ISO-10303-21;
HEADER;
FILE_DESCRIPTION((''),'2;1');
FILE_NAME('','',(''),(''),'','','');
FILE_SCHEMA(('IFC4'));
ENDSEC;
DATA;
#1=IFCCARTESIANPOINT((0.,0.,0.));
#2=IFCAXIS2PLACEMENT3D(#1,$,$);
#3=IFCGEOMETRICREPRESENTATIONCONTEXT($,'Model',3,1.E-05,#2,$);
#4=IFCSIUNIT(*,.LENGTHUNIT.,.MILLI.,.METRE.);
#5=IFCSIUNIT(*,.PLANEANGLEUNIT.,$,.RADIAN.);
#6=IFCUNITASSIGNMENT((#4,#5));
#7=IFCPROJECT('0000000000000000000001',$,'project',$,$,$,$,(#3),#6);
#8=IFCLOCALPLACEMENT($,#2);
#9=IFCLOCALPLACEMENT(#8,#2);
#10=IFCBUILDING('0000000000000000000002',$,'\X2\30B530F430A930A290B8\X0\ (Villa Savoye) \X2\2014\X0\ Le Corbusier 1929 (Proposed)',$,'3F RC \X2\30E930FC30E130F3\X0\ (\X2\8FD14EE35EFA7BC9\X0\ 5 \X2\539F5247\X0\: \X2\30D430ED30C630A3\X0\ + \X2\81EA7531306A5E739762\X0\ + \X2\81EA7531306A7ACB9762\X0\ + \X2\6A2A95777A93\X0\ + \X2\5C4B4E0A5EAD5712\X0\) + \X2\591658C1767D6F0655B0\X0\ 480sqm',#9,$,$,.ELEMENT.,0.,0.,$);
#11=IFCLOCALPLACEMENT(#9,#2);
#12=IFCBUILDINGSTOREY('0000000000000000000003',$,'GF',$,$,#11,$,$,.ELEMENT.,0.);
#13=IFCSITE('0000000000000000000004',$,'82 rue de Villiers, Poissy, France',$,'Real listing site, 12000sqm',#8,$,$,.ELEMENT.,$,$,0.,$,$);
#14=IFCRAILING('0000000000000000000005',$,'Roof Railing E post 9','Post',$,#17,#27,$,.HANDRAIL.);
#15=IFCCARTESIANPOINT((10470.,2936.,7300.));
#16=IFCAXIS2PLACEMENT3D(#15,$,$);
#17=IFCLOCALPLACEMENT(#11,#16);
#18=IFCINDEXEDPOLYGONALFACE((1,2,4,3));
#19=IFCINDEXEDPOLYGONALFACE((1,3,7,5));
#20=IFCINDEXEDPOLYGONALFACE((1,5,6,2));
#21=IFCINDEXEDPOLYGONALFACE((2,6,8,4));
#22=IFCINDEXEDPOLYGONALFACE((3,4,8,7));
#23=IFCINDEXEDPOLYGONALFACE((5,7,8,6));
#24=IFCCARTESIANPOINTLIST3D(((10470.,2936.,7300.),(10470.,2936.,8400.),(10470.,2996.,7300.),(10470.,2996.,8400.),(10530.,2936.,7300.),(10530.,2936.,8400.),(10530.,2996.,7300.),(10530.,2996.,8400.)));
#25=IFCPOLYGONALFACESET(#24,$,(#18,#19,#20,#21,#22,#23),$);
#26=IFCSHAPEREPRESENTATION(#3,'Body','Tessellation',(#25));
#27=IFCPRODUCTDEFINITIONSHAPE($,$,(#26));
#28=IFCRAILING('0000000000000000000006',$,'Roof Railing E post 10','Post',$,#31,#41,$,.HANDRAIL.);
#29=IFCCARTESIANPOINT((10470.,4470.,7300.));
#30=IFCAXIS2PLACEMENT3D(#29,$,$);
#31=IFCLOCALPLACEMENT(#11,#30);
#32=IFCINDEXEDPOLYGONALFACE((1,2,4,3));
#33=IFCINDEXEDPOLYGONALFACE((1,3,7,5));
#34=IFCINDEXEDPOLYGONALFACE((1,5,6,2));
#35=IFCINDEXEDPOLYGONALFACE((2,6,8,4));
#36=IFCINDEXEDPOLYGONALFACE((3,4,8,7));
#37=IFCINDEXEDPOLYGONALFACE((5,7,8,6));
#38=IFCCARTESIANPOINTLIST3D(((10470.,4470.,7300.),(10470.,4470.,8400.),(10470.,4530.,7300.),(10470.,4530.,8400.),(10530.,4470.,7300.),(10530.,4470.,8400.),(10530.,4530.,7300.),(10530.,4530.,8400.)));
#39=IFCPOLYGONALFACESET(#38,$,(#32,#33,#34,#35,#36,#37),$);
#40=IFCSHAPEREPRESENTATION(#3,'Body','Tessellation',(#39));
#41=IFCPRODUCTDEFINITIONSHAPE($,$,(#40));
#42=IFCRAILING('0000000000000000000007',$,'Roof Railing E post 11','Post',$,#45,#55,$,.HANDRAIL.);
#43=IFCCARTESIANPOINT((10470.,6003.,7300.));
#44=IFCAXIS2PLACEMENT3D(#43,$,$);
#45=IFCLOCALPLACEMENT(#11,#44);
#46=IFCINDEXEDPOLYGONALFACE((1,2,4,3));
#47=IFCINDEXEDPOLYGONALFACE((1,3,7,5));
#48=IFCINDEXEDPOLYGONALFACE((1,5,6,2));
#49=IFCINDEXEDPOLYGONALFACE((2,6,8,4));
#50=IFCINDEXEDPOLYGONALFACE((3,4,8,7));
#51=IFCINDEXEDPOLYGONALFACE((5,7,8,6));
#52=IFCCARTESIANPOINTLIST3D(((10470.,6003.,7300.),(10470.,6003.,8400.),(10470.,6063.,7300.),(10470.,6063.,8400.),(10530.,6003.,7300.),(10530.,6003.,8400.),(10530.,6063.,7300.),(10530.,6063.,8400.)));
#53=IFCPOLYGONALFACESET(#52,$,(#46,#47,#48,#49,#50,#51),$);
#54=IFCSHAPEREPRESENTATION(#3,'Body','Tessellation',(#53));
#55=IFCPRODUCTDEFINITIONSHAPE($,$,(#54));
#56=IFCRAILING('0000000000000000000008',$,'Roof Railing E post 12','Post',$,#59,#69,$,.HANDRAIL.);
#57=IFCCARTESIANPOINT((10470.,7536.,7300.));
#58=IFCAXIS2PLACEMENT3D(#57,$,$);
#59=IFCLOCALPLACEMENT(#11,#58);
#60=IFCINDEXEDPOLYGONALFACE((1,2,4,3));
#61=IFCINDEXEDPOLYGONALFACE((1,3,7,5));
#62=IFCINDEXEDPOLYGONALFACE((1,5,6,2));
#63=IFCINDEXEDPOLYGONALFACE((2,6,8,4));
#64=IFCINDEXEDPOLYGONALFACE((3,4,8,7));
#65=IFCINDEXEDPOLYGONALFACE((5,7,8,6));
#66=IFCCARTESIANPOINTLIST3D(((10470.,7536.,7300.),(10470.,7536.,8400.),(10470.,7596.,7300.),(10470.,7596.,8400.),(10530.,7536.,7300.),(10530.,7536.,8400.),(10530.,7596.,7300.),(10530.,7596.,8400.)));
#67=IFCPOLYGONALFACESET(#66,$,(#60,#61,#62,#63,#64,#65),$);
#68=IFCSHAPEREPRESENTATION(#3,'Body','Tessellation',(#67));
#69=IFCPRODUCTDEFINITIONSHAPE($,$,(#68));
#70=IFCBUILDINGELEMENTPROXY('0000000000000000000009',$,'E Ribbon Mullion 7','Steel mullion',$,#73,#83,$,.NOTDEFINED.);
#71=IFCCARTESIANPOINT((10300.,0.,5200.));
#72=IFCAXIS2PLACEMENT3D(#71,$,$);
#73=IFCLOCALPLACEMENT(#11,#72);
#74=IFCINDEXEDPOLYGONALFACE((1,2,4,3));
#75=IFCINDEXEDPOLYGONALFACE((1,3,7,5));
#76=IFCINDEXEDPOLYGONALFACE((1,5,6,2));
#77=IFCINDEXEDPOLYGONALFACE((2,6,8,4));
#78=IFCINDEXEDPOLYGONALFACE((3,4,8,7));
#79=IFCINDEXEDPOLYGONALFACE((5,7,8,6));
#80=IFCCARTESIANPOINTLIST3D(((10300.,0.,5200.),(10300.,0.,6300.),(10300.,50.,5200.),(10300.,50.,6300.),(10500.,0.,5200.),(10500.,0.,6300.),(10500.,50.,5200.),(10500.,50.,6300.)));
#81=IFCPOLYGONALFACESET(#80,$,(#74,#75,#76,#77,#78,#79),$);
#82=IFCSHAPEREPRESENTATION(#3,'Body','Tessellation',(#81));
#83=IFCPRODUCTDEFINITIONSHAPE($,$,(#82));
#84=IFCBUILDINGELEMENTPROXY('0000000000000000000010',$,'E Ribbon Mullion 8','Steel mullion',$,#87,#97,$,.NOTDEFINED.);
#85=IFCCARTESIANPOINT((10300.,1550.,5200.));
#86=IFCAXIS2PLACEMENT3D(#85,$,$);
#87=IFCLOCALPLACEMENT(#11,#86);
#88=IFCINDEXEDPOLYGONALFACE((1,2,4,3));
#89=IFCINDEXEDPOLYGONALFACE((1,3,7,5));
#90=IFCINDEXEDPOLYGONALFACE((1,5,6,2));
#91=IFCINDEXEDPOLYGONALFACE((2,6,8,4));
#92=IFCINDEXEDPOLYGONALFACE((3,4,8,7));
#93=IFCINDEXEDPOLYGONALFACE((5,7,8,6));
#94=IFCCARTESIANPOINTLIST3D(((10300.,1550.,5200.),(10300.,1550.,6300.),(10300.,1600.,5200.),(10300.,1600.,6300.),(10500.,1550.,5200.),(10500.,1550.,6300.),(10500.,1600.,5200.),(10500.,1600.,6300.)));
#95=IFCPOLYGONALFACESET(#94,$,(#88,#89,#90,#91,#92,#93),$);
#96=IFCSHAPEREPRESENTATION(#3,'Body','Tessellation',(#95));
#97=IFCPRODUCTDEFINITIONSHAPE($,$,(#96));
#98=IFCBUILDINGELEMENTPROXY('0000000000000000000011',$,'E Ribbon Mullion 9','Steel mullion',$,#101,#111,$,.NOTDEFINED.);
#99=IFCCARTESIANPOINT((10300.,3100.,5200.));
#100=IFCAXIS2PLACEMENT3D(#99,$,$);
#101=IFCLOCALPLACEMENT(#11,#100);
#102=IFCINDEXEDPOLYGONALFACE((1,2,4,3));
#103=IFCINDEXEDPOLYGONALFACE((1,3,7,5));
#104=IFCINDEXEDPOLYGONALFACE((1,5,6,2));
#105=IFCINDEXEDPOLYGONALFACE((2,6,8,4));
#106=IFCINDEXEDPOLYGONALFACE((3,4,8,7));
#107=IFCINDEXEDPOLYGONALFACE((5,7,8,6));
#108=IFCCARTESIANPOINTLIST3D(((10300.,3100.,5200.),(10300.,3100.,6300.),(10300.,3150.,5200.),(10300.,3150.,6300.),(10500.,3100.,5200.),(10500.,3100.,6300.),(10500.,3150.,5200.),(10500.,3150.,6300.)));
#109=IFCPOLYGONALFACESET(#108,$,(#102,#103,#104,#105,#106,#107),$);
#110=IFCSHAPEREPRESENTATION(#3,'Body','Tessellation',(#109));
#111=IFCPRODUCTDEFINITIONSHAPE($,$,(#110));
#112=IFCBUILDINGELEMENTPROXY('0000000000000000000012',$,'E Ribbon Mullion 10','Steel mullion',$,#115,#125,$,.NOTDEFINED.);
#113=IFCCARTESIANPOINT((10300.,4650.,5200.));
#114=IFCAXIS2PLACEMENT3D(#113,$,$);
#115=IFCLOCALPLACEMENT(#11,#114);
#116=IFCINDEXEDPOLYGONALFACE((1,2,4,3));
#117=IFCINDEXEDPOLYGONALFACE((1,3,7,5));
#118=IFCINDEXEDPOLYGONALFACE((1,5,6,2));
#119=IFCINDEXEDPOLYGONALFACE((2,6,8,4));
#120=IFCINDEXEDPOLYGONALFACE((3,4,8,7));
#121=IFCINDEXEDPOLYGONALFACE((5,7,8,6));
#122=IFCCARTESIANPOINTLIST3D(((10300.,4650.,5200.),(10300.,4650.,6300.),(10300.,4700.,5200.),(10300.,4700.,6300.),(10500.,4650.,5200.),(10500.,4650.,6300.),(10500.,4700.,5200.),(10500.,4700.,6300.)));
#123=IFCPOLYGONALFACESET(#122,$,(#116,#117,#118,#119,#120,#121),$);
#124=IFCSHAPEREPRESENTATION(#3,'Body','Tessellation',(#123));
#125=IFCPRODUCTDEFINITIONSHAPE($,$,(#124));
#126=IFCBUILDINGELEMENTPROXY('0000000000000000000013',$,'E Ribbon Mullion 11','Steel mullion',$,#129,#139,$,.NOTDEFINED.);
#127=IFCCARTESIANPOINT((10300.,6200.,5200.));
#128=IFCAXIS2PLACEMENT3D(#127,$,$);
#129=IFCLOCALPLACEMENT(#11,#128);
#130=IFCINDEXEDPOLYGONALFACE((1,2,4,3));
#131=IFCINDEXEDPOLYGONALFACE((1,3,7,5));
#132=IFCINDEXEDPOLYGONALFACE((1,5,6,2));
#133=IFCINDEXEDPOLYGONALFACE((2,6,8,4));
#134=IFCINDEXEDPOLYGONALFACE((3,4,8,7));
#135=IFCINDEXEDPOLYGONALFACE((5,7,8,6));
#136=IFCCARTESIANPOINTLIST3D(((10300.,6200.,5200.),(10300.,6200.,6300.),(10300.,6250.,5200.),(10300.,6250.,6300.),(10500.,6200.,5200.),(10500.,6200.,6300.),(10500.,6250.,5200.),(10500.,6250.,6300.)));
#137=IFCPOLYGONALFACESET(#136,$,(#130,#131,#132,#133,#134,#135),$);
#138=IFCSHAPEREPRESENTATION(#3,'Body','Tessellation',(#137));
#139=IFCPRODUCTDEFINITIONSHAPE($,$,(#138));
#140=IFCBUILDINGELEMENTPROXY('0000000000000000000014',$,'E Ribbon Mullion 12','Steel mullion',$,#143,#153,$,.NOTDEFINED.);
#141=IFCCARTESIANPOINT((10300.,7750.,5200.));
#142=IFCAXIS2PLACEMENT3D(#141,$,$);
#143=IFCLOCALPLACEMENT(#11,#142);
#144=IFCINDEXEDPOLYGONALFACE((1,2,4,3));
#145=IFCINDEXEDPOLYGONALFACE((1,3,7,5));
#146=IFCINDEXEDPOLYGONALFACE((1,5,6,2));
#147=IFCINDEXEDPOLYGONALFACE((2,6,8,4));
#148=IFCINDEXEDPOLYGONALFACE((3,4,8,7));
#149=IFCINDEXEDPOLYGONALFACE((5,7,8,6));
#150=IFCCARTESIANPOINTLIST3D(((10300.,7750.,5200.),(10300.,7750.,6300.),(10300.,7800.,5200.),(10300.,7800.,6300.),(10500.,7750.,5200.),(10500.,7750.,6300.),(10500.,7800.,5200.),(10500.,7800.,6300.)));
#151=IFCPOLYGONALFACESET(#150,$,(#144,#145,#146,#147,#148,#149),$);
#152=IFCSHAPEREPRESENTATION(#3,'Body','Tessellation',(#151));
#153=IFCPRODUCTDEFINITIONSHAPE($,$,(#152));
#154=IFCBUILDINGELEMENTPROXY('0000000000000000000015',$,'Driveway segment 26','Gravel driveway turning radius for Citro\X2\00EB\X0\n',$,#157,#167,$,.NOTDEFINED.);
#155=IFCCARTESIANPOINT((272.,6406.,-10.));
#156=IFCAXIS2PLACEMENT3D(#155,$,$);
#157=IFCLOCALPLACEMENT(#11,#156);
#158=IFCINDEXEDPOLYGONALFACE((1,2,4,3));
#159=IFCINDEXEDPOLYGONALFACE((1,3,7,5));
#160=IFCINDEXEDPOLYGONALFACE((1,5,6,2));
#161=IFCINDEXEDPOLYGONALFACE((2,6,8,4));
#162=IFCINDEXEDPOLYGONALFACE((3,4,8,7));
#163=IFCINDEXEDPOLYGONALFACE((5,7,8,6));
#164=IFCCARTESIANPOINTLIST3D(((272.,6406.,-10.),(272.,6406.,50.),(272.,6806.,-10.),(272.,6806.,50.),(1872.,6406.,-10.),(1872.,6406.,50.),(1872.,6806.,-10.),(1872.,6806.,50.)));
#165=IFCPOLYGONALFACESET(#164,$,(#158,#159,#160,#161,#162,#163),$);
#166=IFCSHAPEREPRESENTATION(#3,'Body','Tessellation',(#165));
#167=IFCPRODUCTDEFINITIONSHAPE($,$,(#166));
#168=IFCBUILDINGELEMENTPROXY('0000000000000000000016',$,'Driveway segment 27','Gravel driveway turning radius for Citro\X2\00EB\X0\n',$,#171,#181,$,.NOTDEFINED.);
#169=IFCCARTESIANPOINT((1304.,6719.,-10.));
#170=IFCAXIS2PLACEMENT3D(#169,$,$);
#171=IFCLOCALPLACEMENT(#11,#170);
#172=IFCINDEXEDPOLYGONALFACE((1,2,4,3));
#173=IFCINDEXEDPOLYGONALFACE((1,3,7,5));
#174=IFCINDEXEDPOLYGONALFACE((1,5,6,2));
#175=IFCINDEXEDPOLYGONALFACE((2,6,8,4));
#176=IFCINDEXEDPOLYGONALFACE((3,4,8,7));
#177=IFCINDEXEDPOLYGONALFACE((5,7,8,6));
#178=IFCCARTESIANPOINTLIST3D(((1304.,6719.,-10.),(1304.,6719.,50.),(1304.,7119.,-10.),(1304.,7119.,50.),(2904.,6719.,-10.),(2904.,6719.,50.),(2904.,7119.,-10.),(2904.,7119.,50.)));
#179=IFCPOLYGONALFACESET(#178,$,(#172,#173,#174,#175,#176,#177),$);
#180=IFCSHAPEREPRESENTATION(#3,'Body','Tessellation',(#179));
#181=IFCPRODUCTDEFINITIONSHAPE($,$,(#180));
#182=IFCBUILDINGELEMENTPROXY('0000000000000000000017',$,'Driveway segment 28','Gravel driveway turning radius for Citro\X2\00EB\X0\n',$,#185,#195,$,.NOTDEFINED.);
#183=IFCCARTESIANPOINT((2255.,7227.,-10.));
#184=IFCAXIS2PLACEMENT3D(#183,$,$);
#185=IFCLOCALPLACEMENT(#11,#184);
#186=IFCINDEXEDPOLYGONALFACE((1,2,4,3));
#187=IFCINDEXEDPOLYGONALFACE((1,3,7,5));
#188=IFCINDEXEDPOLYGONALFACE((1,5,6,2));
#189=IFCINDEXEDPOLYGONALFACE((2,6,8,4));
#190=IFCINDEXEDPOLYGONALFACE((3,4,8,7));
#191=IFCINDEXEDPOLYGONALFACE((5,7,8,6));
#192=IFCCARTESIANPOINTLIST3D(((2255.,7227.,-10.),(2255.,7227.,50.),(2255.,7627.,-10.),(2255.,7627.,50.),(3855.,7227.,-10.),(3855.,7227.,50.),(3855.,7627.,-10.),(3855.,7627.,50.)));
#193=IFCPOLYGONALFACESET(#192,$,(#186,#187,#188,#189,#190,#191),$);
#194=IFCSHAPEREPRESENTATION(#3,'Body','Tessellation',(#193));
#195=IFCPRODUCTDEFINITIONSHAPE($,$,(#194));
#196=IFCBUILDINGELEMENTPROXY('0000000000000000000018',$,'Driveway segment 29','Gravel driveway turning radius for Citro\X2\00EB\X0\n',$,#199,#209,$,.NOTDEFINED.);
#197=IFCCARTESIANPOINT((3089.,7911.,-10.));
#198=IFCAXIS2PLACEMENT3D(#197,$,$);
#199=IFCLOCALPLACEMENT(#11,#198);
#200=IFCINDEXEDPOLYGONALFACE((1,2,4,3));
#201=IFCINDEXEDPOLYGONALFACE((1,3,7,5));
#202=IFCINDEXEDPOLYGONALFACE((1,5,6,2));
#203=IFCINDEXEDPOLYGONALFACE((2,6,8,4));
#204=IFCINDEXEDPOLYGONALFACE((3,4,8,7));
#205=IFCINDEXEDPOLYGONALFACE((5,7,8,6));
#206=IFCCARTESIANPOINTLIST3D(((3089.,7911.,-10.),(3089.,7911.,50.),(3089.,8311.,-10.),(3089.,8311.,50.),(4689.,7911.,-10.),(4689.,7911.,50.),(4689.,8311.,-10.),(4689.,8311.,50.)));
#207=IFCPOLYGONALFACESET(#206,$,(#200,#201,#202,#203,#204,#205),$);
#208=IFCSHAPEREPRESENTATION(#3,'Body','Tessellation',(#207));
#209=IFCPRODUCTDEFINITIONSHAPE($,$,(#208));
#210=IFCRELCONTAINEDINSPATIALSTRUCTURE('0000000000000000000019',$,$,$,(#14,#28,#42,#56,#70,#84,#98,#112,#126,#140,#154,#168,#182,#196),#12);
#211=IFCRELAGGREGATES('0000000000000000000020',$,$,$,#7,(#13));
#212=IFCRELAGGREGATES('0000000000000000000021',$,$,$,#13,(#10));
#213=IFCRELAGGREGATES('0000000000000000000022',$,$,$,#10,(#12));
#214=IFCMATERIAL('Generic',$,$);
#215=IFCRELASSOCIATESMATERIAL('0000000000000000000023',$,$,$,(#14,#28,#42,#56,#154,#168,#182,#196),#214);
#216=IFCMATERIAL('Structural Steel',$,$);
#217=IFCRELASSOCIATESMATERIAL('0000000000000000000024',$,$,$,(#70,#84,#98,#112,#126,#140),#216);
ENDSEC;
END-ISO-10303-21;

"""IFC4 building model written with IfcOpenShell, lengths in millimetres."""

from ifc_helpers import new_model, si_unit, frame, frame_2d, origin, place, context, project, spatial, rectangle, extrude, material, element, save


model = new_model("IFC4")

# Units and contexts
model_context = context("Model", 3, precision=1e-05, world=origin())
ifc_project = project(units=[si_unit("LENGTHUNIT", "METRE", prefix="MILLI"), si_unit("PLANEANGLEUNIT", "RADIAN")], contexts=[model_context])

# Site, building, storey
site_placement = place(None, origin())
site = spatial("IfcSite", under=ifc_project, at=site_placement, Name="82 rue de Villiers, Poissy, France", ObjectType="Real listing site, 12000sqm", CompositionType="ELEMENT", RefElevation=0.0)
building_placement = place(site_placement, origin())
building = spatial("IfcBuilding", under=site, at=building_placement, Name="サヴォア邸 (Villa Savoye) — Le Corbusier 1929 (Proposed)", ObjectType="3F RC ラーメン (近代建築 5 原則: ピロティ + 自由な平面 + 自由な立面 + 横長窓 + 屋上庭園) + 外壁白漆喰 480sqm", CompositionType="ELEMENT", ElevationOfRefHeight=0.0, ElevationOfTerrain=0.0)
storey_placement = place(building_placement, origin())
storey = spatial("IfcBuildingStorey", under=building, at=storey_placement, Name="GF", CompositionType="ELEMENT", Elevation=0.0)

# Shared definitions
ifc_material_1 = material(Name="Generic")

# Railings
railing_1_placement = place(storey_placement, frame((10470.0, 2936.0, 7300.0)))
element("IfcRailing", 1, at=railing_1_placement, inside=storey, material=ifc_material_1, Name="Roof Railing E post 9", Description="Post", PredefinedType="HANDRAIL", context=model_context, shape_type="SweptSolid", body=[
    extrude(rectangle(XDim=60.0, YDim=60.0, at=frame_2d((30.0, 30.0))), frame((10470.0, 2936.0, 7300.0)), (0.0, 0.0, 1.0), 1100.0),
])
railing_2_placement = place(storey_placement, frame((10470.0, 4470.0, 7300.0)))
element("IfcRailing", 2, at=railing_2_placement, inside=storey, material=ifc_material_1, Name="Roof Railing E post 10", Description="Post", PredefinedType="HANDRAIL", context=model_context, shape_type="SweptSolid", body=[
    extrude(rectangle(XDim=60.0, YDim=60.0, at=frame_2d((30.0, 30.0))), frame((10470.0, 4470.0, 7300.0)), (0.0, 0.0, 1.0), 1100.0),
])
railing_3_placement = place(storey_placement, frame((10470.0, 6003.0, 7300.0)))
element("IfcRailing", 3, at=railing_3_placement, inside=storey, material=ifc_material_1, Name="Roof Railing E post 11", Description="Post", PredefinedType="HANDRAIL", context=model_context, shape_type="SweptSolid", body=[
    extrude(rectangle(XDim=60.0, YDim=60.0, at=frame_2d((30.0, 30.0))), frame((10470.0, 6003.0, 7300.0)), (0.0, 0.0, 1.0), 1100.0),
])
railing_4_placement = place(storey_placement, frame((10470.0, 7536.0, 7300.0)))
element("IfcRailing", 4, at=railing_4_placement, inside=storey, material=ifc_material_1, Name="Roof Railing E post 12", Description="Post", PredefinedType="HANDRAIL", context=model_context, shape_type="SweptSolid", body=[
    extrude(rectangle(XDim=60.0, YDim=60.0, at=frame_2d((30.0, 30.0))), frame((10470.0, 7536.0, 7300.0)), (0.0, 0.0, 1.0), 1100.0),
])

# Building element proxies
ifc_material_2 = material(Name="Structural Steel")
proxy_1_placement = place(storey_placement, frame((10300.0, 0.0, 5200.0)))
element("IfcBuildingElementProxy", 5, at=proxy_1_placement, inside=storey, material=ifc_material_2, Name="E Ribbon Mullion 7", Description="Steel mullion", PredefinedType="NOTDEFINED", context=model_context, shape_type="SweptSolid", body=[
    extrude(rectangle(XDim=200.0, YDim=50.0, at=frame_2d((100.0, 25.0))), frame((10300.0, 0.0, 5200.0)), (0.0, 0.0, 1.0), 1100.0),
])
proxy_2_placement = place(storey_placement, frame((10300.0, 1550.0, 5200.0)))
element("IfcBuildingElementProxy", 6, at=proxy_2_placement, inside=storey, material=ifc_material_2, Name="E Ribbon Mullion 8", Description="Steel mullion", PredefinedType="NOTDEFINED", context=model_context, shape_type="SweptSolid", body=[
    extrude(rectangle(XDim=200.0, YDim=50.0, at=frame_2d((100.0, 25.0))), frame((10300.0, 1550.0, 5200.0)), (0.0, 0.0, 1.0), 1100.0),
])
proxy_3_placement = place(storey_placement, frame((10300.0, 3100.0, 5200.0)))
element("IfcBuildingElementProxy", 7, at=proxy_3_placement, inside=storey, material=ifc_material_2, Name="E Ribbon Mullion 9", Description="Steel mullion", PredefinedType="NOTDEFINED", context=model_context, shape_type="SweptSolid", body=[
    extrude(rectangle(XDim=200.0, YDim=50.0, at=frame_2d((100.0, 25.0))), frame((10300.0, 3100.0, 5200.0)), (0.0, 0.0, 1.0), 1100.0),
])
proxy_4_placement = place(storey_placement, frame((10300.0, 4650.0, 5200.0)))
element("IfcBuildingElementProxy", 8, at=proxy_4_placement, inside=storey, material=ifc_material_2, Name="E Ribbon Mullion 10", Description="Steel mullion", PredefinedType="NOTDEFINED", context=model_context, shape_type="SweptSolid", body=[
    extrude(rectangle(XDim=200.0, YDim=50.0, at=frame_2d((100.0, 25.0))), frame((10300.0, 4650.0, 5200.0)), (0.0, 0.0, 1.0), 1100.0),
])
proxy_5_placement = place(storey_placement, frame((10300.0, 6200.0, 5200.0)))
element("IfcBuildingElementProxy", 9, at=proxy_5_placement, inside=storey, material=ifc_material_2, Name="E Ribbon Mullion 11", Description="Steel mullion", PredefinedType="NOTDEFINED", context=model_context, shape_type="SweptSolid", body=[
    extrude(rectangle(XDim=200.0, YDim=50.0, at=frame_2d((100.0, 25.0))), frame((10300.0, 6200.0, 5200.0)), (0.0, 0.0, 1.0), 1100.0),
])
proxy_6_placement = place(storey_placement, frame((10300.0, 7750.0, 5200.0)))
element("IfcBuildingElementProxy", 10, at=proxy_6_placement, inside=storey, material=ifc_material_2, Name="E Ribbon Mullion 12", Description="Steel mullion", PredefinedType="NOTDEFINED", context=model_context, shape_type="SweptSolid", body=[
    extrude(rectangle(XDim=200.0, YDim=50.0, at=frame_2d((100.0, 25.0))), frame((10300.0, 7750.0, 5200.0)), (0.0, 0.0, 1.0), 1100.0),
])
proxy_7_placement = place(storey_placement, frame((272.0, 6406.0, -10.0)))
element("IfcBuildingElementProxy", 11, at=proxy_7_placement, inside=storey, material=ifc_material_1, Name="Driveway segment 26", Description="Gravel driveway turning radius for Citroën", PredefinedType="NOTDEFINED", context=model_context, shape_type="SweptSolid", body=[
    extrude(rectangle(XDim=1600.0, YDim=400.0, at=frame_2d((800.0, 200.0))), frame((272.0, 6406.0, -10.0)), (0.0, 0.0, 1.0), 60.0),
])
proxy_8_placement = place(storey_placement, frame((1304.0, 6719.0, -10.0)))
element("IfcBuildingElementProxy", 12, at=proxy_8_placement, inside=storey, material=ifc_material_1, Name="Driveway segment 27", Description="Gravel driveway turning radius for Citroën", PredefinedType="NOTDEFINED", context=model_context, shape_type="SweptSolid", body=[
    extrude(rectangle(XDim=1600.0, YDim=400.0, at=frame_2d((800.0, 200.0))), frame((1304.0, 6719.0, -10.0)), (0.0, 0.0, 1.0), 60.0),
])
proxy_9_placement = place(storey_placement, frame((2255.0, 7227.0, -10.0)))
element("IfcBuildingElementProxy", 13, at=proxy_9_placement, inside=storey, material=ifc_material_1, Name="Driveway segment 28", Description="Gravel driveway turning radius for Citroën", PredefinedType="NOTDEFINED", context=model_context, shape_type="SweptSolid", body=[
    extrude(rectangle(XDim=1600.0, YDim=400.0, at=frame_2d((800.0, 200.0))), frame((2255.0, 7227.0, -10.0)), (0.0, 0.0, 1.0), 60.0),
])
proxy_10_placement = place(storey_placement, frame((3089.0, 7911.0, -10.0)))
element("IfcBuildingElementProxy", 14, at=proxy_10_placement, inside=storey, material=ifc_material_1, Name="Driveway segment 29", Description="Gravel driveway turning radius for Citroën", PredefinedType="NOTDEFINED", context=model_context, shape_type="SweptSolid", body=[
    extrude(rectangle(XDim=1600.0, YDim=400.0, at=frame_2d((800.0, 200.0))), frame((3089.0, 7911.0, -10.0)), (0.0, 0.0, 1.0), 60.0),
])

save(model, "model.ifc")
